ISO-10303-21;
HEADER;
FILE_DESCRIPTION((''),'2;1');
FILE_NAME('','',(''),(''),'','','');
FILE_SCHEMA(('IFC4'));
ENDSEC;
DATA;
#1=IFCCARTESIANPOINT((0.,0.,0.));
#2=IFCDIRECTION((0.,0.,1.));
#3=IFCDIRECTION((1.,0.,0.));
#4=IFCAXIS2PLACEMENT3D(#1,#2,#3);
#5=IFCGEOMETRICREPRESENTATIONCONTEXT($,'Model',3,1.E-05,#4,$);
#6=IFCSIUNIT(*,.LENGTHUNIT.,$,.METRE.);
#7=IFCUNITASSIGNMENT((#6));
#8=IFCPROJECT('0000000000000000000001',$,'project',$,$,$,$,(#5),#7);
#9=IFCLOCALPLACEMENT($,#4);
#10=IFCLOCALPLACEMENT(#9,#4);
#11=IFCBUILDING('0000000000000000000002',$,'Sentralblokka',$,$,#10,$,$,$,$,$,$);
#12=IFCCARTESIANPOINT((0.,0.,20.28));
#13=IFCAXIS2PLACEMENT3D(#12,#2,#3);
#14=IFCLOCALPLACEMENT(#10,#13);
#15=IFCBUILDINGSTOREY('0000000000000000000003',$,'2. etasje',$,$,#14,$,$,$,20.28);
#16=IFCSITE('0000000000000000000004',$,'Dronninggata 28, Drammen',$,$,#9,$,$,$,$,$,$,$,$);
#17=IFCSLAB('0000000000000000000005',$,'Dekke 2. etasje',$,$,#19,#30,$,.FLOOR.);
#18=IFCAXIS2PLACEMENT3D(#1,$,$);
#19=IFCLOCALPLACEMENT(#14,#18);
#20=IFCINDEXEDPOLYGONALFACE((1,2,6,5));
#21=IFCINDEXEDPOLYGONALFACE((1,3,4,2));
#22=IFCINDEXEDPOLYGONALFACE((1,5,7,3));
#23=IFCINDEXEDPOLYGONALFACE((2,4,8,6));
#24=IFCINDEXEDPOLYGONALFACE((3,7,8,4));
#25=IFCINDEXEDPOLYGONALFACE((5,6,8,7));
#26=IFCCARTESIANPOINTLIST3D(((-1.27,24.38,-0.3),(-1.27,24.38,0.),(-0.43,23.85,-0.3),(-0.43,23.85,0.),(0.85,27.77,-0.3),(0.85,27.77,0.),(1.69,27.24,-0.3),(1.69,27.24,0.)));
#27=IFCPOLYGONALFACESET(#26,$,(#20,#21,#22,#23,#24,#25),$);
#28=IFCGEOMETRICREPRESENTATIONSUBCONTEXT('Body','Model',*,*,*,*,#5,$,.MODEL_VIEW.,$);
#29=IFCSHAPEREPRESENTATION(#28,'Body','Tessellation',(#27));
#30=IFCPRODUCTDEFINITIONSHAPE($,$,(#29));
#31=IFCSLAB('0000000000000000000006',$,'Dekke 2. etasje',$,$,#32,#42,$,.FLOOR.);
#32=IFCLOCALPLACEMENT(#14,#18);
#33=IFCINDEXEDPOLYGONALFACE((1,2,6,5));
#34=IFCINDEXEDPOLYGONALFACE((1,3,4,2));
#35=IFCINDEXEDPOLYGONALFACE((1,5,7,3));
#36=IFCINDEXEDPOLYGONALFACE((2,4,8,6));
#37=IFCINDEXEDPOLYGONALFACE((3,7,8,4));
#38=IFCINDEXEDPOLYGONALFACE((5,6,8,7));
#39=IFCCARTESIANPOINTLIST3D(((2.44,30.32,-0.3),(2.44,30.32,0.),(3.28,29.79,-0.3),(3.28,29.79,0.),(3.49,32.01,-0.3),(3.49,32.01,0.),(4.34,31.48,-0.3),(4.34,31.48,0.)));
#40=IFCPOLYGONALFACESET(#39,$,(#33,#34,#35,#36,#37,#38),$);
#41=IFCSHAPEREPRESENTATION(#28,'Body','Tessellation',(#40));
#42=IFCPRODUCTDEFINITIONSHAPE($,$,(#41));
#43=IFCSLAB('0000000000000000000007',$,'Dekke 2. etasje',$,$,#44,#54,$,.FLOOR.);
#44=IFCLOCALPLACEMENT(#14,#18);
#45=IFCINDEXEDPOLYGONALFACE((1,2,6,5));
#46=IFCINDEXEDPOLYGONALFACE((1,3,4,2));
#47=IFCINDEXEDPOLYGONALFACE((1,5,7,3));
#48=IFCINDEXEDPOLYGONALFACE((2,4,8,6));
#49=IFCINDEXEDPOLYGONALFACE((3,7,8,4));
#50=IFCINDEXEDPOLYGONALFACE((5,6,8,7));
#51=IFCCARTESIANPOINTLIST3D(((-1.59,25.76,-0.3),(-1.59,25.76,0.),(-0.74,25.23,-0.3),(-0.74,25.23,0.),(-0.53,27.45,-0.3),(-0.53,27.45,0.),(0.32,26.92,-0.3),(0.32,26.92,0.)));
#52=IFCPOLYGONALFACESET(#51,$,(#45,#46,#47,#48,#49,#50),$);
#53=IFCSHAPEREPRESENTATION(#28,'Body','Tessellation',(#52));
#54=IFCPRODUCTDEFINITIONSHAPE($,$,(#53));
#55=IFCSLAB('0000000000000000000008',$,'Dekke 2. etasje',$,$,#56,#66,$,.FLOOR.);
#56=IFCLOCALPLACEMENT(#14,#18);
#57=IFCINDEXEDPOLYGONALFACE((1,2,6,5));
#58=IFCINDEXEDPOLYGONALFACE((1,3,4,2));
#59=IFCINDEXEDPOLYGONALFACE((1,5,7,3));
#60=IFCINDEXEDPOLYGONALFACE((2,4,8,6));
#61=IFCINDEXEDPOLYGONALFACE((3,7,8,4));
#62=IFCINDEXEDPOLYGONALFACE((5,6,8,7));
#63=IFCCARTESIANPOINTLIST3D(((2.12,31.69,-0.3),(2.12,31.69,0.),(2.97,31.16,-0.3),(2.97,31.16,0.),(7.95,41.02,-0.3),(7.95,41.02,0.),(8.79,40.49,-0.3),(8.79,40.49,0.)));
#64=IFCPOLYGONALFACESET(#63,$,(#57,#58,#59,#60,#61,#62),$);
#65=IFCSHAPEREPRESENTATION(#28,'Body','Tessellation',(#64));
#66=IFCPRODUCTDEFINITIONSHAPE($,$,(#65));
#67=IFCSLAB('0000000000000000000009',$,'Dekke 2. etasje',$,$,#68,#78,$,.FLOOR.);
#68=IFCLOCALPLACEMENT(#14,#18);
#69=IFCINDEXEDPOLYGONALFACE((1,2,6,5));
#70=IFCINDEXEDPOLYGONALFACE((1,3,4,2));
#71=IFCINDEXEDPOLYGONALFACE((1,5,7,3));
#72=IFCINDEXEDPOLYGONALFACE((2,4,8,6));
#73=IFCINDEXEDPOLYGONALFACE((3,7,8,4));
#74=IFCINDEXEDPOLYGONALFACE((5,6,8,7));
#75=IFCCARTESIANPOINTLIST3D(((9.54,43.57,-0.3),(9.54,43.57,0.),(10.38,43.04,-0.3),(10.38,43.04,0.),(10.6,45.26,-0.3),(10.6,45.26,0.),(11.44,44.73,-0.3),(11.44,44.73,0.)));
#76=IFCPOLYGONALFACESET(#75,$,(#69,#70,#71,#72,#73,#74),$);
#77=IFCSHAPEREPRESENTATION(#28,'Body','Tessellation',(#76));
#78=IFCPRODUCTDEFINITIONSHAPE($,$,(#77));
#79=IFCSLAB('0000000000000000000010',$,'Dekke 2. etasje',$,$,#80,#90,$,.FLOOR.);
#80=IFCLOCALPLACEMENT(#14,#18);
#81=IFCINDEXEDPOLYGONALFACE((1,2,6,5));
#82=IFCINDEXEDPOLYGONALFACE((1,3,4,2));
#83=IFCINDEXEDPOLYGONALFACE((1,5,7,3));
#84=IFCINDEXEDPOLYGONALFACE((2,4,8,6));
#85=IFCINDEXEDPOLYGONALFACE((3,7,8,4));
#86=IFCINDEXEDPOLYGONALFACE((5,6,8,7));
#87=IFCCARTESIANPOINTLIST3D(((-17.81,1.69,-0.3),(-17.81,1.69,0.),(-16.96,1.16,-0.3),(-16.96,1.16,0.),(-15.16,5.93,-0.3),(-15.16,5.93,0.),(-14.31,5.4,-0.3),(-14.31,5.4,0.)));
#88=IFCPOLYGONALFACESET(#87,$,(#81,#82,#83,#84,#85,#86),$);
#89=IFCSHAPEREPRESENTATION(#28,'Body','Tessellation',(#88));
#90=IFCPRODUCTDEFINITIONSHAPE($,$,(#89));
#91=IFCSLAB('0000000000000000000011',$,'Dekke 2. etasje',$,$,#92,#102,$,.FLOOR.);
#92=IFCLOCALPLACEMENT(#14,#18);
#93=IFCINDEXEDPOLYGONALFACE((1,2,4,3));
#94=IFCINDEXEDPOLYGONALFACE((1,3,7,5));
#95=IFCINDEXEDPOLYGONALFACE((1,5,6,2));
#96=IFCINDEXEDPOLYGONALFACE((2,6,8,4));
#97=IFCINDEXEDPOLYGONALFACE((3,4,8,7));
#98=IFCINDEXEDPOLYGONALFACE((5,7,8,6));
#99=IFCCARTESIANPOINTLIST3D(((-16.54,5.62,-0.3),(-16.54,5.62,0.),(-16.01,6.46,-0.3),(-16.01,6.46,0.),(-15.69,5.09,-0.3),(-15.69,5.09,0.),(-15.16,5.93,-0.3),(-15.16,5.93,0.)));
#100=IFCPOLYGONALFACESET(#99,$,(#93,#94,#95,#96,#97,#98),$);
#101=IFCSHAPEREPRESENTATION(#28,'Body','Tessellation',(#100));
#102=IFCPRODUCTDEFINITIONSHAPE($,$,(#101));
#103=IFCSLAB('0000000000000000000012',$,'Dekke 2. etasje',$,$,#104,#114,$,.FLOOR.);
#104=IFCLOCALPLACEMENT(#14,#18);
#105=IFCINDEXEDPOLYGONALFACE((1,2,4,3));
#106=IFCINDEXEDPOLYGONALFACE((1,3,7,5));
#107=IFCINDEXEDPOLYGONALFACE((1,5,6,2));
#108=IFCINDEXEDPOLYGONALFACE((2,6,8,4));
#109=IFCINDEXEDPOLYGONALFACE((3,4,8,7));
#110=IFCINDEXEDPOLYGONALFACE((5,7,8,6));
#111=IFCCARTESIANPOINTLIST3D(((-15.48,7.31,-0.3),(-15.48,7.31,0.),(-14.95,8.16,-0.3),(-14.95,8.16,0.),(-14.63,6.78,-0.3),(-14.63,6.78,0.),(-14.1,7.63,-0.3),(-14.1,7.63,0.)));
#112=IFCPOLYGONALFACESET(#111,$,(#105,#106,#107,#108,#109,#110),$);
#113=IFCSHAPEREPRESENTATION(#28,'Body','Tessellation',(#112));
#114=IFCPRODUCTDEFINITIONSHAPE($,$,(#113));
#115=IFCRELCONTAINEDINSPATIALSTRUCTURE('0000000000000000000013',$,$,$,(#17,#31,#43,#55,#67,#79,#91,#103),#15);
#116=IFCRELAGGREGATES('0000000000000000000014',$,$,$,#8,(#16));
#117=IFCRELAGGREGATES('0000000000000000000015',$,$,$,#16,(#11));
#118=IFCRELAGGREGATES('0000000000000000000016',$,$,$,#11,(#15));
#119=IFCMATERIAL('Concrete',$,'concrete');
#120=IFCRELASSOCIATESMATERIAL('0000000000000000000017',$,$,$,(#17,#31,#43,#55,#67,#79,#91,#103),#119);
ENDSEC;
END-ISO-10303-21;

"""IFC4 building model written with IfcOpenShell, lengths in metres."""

from ifc_helpers import new_model, si_unit, frame, origin_with_axes, place, context, subcontext, project, spatial, polyline, outline, extrude, material, element, save


model = new_model("IFC4")

# Units and contexts
model_context = context("Model", 3, precision=1e-05, world=origin_with_axes())
body_context = subcontext(model_context, "Body", "Model", "MODEL_VIEW")
ifc_project = project(units=[si_unit("LENGTHUNIT", "METRE")], contexts=[model_context])

# Site, building, storey
site_placement = place(None, origin_with_axes())
site = spatial("IfcSite", under=ifc_project, at=site_placement, Name="Dronninggata 28, Drammen")
building_placement = place(site_placement, origin_with_axes())
building = spatial("IfcBuilding", under=site, at=building_placement, Name="Sentralblokka")
storey_placement = place(building_placement, frame((0.0, 0.0, 20.28), z_axis=(0.0, 0.0, 1.0), x_axis=(1.0, 0.0, 0.0)))
storey = spatial("IfcBuildingStorey", under=building, at=storey_placement, Name="2. etasje", Elevation=20.28)

# Slabs
ifc_material = material(Name="Concrete", Category="concrete")
slab_1_placement = place(storey_placement, frame((0.0, 0.0, -20.28), z_axis=(0.0, 0.0, 1.0), x_axis=(1.0, 0.0, 0.0)))
element("IfcSlab", 1, at=slab_1_placement, inside=storey, material=ifc_material, Name="Dekke 2. etasje", PredefinedType="FLOOR", context=body_context, shape_type="SweptSolid", body=[
    extrude(outline(polyline([(-0.43, 23.85), (1.69, 27.24), (0.85, 27.77), (-1.27, 24.38), (-0.43, 23.85)])), frame((0.0, 0.0, 19.98)), (0.0, 0.0, 1.0), 0.3),
])
slab_2_placement = place(storey_placement, frame((0.0, 0.0, -20.28), z_axis=(0.0, 0.0, 1.0), x_axis=(1.0, 0.0, 0.0)))
element("IfcSlab", 2, at=slab_2_placement, inside=storey, material=ifc_material, Name="Dekke 2. etasje", PredefinedType="FLOOR", context=body_context, shape_type="SweptSolid", body=[
    extrude(outline(polyline([(3.28, 29.79), (4.34, 31.48), (3.49, 32.01), (2.44, 30.32), (3.28, 29.79)])), frame((0.0, 0.0, 19.98)), (0.0, 0.0, 1.0), 0.3),
])
slab_3_placement = place(storey_placement, frame((0.0, 0.0, -20.28), z_axis=(0.0, 0.0, 1.0), x_axis=(1.0, 0.0, 0.0)))
element("IfcSlab", 3, at=slab_3_placement, inside=storey, material=ifc_material, Name="Dekke 2. etasje", PredefinedType="FLOOR", context=body_context, shape_type="SweptSolid", body=[
    extrude(outline(polyline([(-0.74, 25.23), (0.32, 26.92), (-0.53, 27.45), (-1.59, 25.76), (-0.74, 25.23)])), frame((0.0, 0.0, 19.98)), (0.0, 0.0, 1.0), 0.3),
])
slab_4_placement = place(storey_placement, frame((0.0, 0.0, -20.28), z_axis=(0.0, 0.0, 1.0), x_axis=(1.0, 0.0, 0.0)))
element("IfcSlab", 4, at=slab_4_placement, inside=storey, material=ifc_material, Name="Dekke 2. etasje", PredefinedType="FLOOR", context=body_context, shape_type="SweptSolid", body=[
    extrude(outline(polyline([(2.97, 31.16), (8.79, 40.49), (7.95, 41.02), (2.12, 31.69), (2.97, 31.16)])), frame((0.0, 0.0, 19.98)), (0.0, 0.0, 1.0), 0.3),
])
slab_5_placement = place(storey_placement, frame((0.0, 0.0, -20.28), z_axis=(0.0, 0.0, 1.0), x_axis=(1.0, 0.0, 0.0)))
element("IfcSlab", 5, at=slab_5_placement, inside=storey, material=ifc_material, Name="Dekke 2. etasje", PredefinedType="FLOOR", context=body_context, shape_type="SweptSolid", body=[
    extrude(outline(polyline([(10.38, 43.04), (11.44, 44.73), (10.6, 45.26), (9.54, 43.57), (10.38, 43.04)])), frame((0.0, 0.0, 19.98)), (0.0, 0.0, 1.0), 0.3),
])
slab_6_placement = place(storey_placement, frame((0.0, 0.0, -20.28), z_axis=(0.0, 0.0, 1.0), x_axis=(1.0, 0.0, 0.0)))
element("IfcSlab", 6, at=slab_6_placement, inside=storey, material=ifc_material, Name="Dekke 2. etasje", PredefinedType="FLOOR", context=body_context, shape_type="SweptSolid", body=[
    extrude(outline(polyline([(-16.96, 1.16), (-14.31, 5.4), (-15.16, 5.93), (-17.81, 1.69), (-16.96, 1.16)])), frame((0.0, 0.0, 19.98)), (0.0, 0.0, 1.0), 0.3),
])
slab_7_placement = place(storey_placement, frame((0.0, 0.0, -20.28), z_axis=(0.0, 0.0, 1.0), x_axis=(1.0, 0.0, 0.0)))
element("IfcSlab", 7, at=slab_7_placement, inside=storey, material=ifc_material, Name="Dekke 2. etasje", PredefinedType="FLOOR", context=body_context, shape_type="SweptSolid", body=[
    extrude(outline(polyline([(-15.69, 5.09), (-15.16, 5.93), (-16.01, 6.46), (-16.54, 5.62), (-15.69, 5.09)])), frame((0.0, 0.0, 19.98)), (0.0, 0.0, 1.0), 0.3),
])
slab_8_placement = place(storey_placement, frame((0.0, 0.0, -20.28), z_axis=(0.0, 0.0, 1.0), x_axis=(1.0, 0.0, 0.0)))
element("IfcSlab", 8, at=slab_8_placement, inside=storey, material=ifc_material, Name="Dekke 2. etasje", PredefinedType="FLOOR", context=body_context, shape_type="SweptSolid", body=[
    extrude(outline(polyline([(-14.63, 6.78), (-14.1, 7.63), (-14.95, 8.16), (-15.48, 7.31), (-14.63, 6.78)])), frame((0.0, 0.0, 19.98)), (0.0, 0.0, 1.0), 0.3),
])

save(model, "model.ifc")
